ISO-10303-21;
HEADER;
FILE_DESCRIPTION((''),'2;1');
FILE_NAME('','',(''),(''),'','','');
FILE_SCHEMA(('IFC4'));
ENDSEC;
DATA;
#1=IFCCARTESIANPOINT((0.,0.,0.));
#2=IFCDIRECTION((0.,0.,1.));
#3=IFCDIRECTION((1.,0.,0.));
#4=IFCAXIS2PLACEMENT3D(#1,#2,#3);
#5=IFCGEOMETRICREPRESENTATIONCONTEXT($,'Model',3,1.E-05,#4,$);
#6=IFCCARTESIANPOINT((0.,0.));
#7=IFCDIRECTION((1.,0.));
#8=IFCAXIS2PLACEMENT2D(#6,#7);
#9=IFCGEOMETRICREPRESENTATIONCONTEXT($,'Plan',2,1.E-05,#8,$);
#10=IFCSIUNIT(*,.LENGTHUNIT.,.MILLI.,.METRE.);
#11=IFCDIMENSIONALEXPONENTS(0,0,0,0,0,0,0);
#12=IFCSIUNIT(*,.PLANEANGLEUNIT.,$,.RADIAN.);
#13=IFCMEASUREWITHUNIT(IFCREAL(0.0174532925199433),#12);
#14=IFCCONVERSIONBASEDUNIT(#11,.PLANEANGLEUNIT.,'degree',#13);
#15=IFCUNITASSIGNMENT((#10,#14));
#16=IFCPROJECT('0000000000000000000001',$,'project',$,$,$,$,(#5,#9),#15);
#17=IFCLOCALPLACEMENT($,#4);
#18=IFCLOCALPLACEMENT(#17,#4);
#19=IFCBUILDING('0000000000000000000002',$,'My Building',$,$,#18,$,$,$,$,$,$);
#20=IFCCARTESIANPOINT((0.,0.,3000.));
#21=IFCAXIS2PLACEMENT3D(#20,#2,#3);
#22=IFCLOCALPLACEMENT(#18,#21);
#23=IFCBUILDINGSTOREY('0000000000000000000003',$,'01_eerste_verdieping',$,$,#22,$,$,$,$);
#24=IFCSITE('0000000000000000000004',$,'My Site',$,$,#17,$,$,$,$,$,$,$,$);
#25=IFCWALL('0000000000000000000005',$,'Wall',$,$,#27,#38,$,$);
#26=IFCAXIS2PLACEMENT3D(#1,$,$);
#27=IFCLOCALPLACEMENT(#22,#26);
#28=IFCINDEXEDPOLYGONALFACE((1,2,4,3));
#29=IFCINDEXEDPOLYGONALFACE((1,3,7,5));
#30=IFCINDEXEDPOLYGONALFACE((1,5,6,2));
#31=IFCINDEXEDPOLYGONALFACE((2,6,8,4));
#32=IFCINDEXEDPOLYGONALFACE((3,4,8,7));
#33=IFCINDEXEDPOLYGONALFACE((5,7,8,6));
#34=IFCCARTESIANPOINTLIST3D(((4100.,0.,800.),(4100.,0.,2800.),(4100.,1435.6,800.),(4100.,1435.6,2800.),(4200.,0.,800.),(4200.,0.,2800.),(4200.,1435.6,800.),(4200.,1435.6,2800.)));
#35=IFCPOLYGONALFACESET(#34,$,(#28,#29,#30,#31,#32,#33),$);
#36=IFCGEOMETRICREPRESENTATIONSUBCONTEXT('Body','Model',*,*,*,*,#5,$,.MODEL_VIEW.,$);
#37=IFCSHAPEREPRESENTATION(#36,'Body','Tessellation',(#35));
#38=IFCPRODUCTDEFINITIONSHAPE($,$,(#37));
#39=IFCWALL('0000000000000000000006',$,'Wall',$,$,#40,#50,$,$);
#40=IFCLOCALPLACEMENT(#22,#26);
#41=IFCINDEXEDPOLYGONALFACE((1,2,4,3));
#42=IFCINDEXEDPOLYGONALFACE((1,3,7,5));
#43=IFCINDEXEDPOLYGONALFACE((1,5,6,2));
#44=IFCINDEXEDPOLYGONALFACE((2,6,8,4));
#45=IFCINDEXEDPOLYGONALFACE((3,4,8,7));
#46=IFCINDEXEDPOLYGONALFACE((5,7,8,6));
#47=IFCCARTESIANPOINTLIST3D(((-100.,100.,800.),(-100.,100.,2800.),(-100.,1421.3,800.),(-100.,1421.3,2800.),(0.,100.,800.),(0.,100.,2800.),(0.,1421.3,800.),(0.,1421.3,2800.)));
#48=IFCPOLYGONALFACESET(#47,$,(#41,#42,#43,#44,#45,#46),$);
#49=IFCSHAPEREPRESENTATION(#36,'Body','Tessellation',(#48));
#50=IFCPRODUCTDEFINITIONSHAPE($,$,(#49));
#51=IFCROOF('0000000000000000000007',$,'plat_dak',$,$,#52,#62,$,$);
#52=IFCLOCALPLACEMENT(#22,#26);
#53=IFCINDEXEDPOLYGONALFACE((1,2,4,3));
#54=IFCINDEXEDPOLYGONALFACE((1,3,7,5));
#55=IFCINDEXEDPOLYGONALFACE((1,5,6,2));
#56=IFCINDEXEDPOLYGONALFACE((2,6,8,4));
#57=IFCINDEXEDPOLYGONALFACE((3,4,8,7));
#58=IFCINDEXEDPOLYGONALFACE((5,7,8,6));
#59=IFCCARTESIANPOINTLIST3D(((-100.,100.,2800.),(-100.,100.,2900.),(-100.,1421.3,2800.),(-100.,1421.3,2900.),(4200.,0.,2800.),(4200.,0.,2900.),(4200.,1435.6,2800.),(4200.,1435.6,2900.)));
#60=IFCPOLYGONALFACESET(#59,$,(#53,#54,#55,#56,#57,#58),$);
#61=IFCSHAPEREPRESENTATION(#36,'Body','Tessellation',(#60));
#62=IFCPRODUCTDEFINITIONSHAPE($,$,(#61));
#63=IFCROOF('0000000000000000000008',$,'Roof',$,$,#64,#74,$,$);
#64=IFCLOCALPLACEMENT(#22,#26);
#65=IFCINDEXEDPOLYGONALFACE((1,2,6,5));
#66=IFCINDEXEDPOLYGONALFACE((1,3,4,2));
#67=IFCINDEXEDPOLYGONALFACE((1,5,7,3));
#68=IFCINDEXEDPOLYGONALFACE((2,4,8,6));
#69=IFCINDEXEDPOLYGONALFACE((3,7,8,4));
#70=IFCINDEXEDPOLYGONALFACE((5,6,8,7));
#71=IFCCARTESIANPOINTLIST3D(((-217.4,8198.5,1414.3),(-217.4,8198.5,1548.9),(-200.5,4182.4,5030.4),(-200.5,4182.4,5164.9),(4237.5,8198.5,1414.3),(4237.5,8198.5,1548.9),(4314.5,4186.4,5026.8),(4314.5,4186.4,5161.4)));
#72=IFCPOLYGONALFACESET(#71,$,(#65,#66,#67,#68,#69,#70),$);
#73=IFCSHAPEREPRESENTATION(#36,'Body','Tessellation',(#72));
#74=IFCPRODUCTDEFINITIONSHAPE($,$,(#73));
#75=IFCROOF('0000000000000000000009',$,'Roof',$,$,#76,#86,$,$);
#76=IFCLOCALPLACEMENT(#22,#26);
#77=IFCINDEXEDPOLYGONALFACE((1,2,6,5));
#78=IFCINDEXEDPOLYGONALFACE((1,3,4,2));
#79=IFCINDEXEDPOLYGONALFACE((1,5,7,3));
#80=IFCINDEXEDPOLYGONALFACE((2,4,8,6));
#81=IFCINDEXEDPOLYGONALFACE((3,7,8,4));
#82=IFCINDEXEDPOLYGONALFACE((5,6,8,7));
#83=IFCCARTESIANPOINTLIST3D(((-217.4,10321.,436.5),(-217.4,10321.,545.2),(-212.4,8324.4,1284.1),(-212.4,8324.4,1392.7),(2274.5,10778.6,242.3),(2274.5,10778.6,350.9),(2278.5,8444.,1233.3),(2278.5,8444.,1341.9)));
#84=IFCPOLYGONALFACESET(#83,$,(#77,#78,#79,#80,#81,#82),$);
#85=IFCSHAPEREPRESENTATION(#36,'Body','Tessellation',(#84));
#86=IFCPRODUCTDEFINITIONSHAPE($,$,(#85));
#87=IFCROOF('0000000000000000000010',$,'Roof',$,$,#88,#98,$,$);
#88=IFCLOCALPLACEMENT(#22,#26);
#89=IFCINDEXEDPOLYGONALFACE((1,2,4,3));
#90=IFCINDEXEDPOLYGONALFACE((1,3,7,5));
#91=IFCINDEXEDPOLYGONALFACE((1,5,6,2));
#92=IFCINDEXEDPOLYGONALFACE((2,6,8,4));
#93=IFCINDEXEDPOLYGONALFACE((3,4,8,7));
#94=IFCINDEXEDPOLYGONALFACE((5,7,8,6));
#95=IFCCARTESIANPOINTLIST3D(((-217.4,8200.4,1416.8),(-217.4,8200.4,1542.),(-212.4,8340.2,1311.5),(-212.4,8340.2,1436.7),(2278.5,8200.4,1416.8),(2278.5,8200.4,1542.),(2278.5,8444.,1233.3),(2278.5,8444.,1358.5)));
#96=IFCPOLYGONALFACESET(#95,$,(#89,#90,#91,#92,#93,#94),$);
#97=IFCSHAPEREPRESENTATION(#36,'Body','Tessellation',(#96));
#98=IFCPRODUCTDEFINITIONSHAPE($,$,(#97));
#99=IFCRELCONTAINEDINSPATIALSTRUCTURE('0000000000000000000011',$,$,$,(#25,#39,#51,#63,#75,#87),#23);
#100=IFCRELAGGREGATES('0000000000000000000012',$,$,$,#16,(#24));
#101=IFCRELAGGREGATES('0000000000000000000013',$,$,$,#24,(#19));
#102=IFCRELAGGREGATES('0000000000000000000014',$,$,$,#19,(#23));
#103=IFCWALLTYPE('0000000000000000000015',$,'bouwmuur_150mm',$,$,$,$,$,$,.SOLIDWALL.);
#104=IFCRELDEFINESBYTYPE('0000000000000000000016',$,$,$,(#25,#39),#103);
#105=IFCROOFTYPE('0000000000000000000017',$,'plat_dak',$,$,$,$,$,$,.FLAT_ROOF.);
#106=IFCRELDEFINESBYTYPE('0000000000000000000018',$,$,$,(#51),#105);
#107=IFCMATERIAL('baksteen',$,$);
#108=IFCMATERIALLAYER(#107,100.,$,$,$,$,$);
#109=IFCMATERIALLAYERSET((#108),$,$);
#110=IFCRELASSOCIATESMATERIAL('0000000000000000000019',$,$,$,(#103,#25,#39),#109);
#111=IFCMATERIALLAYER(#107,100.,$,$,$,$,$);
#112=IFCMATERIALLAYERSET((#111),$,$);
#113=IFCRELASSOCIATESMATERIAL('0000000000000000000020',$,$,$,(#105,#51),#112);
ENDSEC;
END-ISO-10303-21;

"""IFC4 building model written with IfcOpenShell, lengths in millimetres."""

from ifc_helpers import new_model, entity, si_unit, converted_unit, frame, origin_with_axes, origin_2d_with_axis, place, context, subcontext, project, spatial, line, indexed_curve, outline, extrude, material, layer, layer_set, layer_usage, type_object, element, save


model = new_model("IFC4")

# Units and contexts
model_context = context("Model", 3, precision=1e-05, world=origin_with_axes())
plan_context = context("Plan", 2, precision=1e-05, world=origin_2d_with_axis())
body_context = subcontext(model_context, "Body", "Model", "MODEL_VIEW")
ifc_project = project(units=[si_unit("LENGTHUNIT", "METRE", prefix="MILLI"), converted_unit("PLANEANGLEUNIT", "degree", entity("IfcReal", 0.0174532925199433), si_unit("PLANEANGLEUNIT", "RADIAN"), dimensions=[0, 0, 0, 0, 0, 0, 0])], contexts=[model_context, plan_context])

# Site, building, storey
site_placement = place(None, origin_with_axes())
site = spatial("IfcSite", under=ifc_project, at=site_placement, Name="My Site")
building_placement = place(site_placement, origin_with_axes())
building = spatial("IfcBuilding", under=site, at=building_placement, Name="My Building")
storey_placement = place(building_placement, frame((0.0, 0.0, 3000.0), z_axis=(0.0, 0.0, 1.0), x_axis=(1.0, 0.0, 0.0)))
storey = spatial("IfcBuildingStorey", under=building, at=storey_placement, Name="01_eerste_verdieping")

# Shared definitions
ifc_material = material(Name="baksteen")

# Walls
ifc_layer_1 = layer(ifc_material, 100.0)
ifc_layer_set_1 = layer_set([ifc_layer_1])
wall_type = type_object("IfcWallType", Name="bouwmuur_150mm", PredefinedType="SOLIDWALL", material=ifc_layer_set_1)
ifc_layer_usage_1 = layer_usage(ifc_layer_set_1, "AXIS2", "POSITIVE", 0.0)
wall_1_placement = place(storey_placement, frame((4100.0, 1435.6, 800.0), z_axis=(0.0, 0.0, 1.0), x_axis=(-0.000001, -1.0, 0.0)))
element("IfcWall", 1, at=wall_1_placement, inside=storey, type_object=wall_type, material=ifc_layer_usage_1, Name="Wall", context=body_context, shape_type="SweptSolid", body=[
    extrude(outline(indexed_curve([(0.0, 0.0), (0.0, 100.0), (1435.6, 100.0), (1435.6, 0.0), (0.0, 0.0)], self_intersect=False)), origin_with_axes(), (0.0, 0.0, 1.0), 2000.0),
])
ifc_layer_usage_2 = layer_usage(ifc_layer_set_1, "AXIS2", "POSITIVE", 0.0)
wall_2_placement = place(storey_placement, frame((-100.0, 1421.3, 800.0), z_axis=(0.0, 0.0, 1.0), x_axis=(-0.000001, -1.0, 0.0)))
element("IfcWall", 2, at=wall_2_placement, inside=storey, type_object=wall_type, material=ifc_layer_usage_2, Name="Wall", context=body_context, shape_type="SweptSolid", body=[
    extrude(outline(indexed_curve([(0.0, 0.0), (0.0, 100.0), (1321.3, 100.0), (1321.3, 0.0), (0.0, 0.0)], self_intersect=False)), origin_with_axes(), (0.0, 0.0, 1.0), 2000.0),
])

# Roofs
ifc_layer_2 = layer(ifc_material, 100.0)
ifc_layer_set_2 = layer_set([ifc_layer_2])
ifc_layer_usage_3 = layer_usage(ifc_layer_set_2, "AXIS3", "POSITIVE", 0.0)
roof_type = type_object("IfcRoofType", Name="plat_dak", PredefinedType="FLAT_ROOF", material=ifc_layer_set_2)
roof_1_placement = place(storey_placement, frame((-100.0, 100.0, 2800.0), z_axis=(0.0, 0.0, 1.0), x_axis=(1.0, 0.0, 0.0)))
element("IfcRoof", 3, at=roof_1_placement, inside=storey, type_object=roof_type, material=ifc_layer_usage_3, Name="plat_dak", context=body_context, shape_type="SweptSolid", body=[
    extrude(outline(indexed_curve([(0.0, 0.0), (4300.0, -100.0), (4300.0, 1335.6), (0.0, 1321.3)], segments=[line(4, 1), line(1, 2), line(2, 3), line(3, 4)], self_intersect=False)), None, (0.0, 0.0, 1.0), 100.0),
])
roof_2_placement = place(storey_placement, frame((4237.5, 8198.5, 1414.3), z_axis=(0.0, 0.669131, 0.743145), x_axis=(-1.0, 0.0, 0.0)))
element("IfcRoof", 4, at=roof_2_placement, inside=storey, Name="Roof", context=body_context, shape_type="SweptSolid", body=[
    extrude(outline(indexed_curve([(0.0, 0.0), (4455.0, 0.0), (4438.0, 5404.1), (-77.0, 5398.9)], segments=[line(3, 2), line(2, 1), line(1, 4), line(4, 3)], self_intersect=False)), None, (0.0, 0.669131, 0.743145), 134.6),
])
roof_3_placement = place(storey_placement, frame((2274.5, 10778.6, 242.3), z_axis=(0.0, 0.390731, 0.920505), x_axis=(-1.0, 0.0, 0.0)))
element("IfcRoof", 5, at=roof_3_placement, inside=storey, Name="Roof", context=body_context, shape_type="SweptSolid", body=[
    extrude(outline(indexed_curve([(-4.0, 2536.2), (0.0, 0.0), (2491.9, 497.1), (2486.9, 2666.2)], segments=[line(4, 1), line(1, 2), line(2, 3), line(3, 4)], self_intersect=False)), None, (0.0, 0.390731, 0.920505), 108.6),
])
roof_4_placement = place(storey_placement, frame((2278.5, 8444.0, 1233.3), z_axis=(0.0, 0.601815, 0.798636), x_axis=(-1.0, 0.0, 0.0)))
element("IfcRoof", 6, at=roof_4_placement, inside=storey, Name="Roof", context=body_context, shape_type="SweptSolid", body=[
    extrude(outline(indexed_curve([(0.0, 305.0), (2496.0, 305.0), (2491.0, 129.9), (0.0, 0.0)], segments=[line(4, 1), line(1, 2), line(2, 3), line(3, 4)], self_intersect=False)), None, (0.0, 0.601815, 0.798636), 125.2),
])

save(model, "model.ifc")
